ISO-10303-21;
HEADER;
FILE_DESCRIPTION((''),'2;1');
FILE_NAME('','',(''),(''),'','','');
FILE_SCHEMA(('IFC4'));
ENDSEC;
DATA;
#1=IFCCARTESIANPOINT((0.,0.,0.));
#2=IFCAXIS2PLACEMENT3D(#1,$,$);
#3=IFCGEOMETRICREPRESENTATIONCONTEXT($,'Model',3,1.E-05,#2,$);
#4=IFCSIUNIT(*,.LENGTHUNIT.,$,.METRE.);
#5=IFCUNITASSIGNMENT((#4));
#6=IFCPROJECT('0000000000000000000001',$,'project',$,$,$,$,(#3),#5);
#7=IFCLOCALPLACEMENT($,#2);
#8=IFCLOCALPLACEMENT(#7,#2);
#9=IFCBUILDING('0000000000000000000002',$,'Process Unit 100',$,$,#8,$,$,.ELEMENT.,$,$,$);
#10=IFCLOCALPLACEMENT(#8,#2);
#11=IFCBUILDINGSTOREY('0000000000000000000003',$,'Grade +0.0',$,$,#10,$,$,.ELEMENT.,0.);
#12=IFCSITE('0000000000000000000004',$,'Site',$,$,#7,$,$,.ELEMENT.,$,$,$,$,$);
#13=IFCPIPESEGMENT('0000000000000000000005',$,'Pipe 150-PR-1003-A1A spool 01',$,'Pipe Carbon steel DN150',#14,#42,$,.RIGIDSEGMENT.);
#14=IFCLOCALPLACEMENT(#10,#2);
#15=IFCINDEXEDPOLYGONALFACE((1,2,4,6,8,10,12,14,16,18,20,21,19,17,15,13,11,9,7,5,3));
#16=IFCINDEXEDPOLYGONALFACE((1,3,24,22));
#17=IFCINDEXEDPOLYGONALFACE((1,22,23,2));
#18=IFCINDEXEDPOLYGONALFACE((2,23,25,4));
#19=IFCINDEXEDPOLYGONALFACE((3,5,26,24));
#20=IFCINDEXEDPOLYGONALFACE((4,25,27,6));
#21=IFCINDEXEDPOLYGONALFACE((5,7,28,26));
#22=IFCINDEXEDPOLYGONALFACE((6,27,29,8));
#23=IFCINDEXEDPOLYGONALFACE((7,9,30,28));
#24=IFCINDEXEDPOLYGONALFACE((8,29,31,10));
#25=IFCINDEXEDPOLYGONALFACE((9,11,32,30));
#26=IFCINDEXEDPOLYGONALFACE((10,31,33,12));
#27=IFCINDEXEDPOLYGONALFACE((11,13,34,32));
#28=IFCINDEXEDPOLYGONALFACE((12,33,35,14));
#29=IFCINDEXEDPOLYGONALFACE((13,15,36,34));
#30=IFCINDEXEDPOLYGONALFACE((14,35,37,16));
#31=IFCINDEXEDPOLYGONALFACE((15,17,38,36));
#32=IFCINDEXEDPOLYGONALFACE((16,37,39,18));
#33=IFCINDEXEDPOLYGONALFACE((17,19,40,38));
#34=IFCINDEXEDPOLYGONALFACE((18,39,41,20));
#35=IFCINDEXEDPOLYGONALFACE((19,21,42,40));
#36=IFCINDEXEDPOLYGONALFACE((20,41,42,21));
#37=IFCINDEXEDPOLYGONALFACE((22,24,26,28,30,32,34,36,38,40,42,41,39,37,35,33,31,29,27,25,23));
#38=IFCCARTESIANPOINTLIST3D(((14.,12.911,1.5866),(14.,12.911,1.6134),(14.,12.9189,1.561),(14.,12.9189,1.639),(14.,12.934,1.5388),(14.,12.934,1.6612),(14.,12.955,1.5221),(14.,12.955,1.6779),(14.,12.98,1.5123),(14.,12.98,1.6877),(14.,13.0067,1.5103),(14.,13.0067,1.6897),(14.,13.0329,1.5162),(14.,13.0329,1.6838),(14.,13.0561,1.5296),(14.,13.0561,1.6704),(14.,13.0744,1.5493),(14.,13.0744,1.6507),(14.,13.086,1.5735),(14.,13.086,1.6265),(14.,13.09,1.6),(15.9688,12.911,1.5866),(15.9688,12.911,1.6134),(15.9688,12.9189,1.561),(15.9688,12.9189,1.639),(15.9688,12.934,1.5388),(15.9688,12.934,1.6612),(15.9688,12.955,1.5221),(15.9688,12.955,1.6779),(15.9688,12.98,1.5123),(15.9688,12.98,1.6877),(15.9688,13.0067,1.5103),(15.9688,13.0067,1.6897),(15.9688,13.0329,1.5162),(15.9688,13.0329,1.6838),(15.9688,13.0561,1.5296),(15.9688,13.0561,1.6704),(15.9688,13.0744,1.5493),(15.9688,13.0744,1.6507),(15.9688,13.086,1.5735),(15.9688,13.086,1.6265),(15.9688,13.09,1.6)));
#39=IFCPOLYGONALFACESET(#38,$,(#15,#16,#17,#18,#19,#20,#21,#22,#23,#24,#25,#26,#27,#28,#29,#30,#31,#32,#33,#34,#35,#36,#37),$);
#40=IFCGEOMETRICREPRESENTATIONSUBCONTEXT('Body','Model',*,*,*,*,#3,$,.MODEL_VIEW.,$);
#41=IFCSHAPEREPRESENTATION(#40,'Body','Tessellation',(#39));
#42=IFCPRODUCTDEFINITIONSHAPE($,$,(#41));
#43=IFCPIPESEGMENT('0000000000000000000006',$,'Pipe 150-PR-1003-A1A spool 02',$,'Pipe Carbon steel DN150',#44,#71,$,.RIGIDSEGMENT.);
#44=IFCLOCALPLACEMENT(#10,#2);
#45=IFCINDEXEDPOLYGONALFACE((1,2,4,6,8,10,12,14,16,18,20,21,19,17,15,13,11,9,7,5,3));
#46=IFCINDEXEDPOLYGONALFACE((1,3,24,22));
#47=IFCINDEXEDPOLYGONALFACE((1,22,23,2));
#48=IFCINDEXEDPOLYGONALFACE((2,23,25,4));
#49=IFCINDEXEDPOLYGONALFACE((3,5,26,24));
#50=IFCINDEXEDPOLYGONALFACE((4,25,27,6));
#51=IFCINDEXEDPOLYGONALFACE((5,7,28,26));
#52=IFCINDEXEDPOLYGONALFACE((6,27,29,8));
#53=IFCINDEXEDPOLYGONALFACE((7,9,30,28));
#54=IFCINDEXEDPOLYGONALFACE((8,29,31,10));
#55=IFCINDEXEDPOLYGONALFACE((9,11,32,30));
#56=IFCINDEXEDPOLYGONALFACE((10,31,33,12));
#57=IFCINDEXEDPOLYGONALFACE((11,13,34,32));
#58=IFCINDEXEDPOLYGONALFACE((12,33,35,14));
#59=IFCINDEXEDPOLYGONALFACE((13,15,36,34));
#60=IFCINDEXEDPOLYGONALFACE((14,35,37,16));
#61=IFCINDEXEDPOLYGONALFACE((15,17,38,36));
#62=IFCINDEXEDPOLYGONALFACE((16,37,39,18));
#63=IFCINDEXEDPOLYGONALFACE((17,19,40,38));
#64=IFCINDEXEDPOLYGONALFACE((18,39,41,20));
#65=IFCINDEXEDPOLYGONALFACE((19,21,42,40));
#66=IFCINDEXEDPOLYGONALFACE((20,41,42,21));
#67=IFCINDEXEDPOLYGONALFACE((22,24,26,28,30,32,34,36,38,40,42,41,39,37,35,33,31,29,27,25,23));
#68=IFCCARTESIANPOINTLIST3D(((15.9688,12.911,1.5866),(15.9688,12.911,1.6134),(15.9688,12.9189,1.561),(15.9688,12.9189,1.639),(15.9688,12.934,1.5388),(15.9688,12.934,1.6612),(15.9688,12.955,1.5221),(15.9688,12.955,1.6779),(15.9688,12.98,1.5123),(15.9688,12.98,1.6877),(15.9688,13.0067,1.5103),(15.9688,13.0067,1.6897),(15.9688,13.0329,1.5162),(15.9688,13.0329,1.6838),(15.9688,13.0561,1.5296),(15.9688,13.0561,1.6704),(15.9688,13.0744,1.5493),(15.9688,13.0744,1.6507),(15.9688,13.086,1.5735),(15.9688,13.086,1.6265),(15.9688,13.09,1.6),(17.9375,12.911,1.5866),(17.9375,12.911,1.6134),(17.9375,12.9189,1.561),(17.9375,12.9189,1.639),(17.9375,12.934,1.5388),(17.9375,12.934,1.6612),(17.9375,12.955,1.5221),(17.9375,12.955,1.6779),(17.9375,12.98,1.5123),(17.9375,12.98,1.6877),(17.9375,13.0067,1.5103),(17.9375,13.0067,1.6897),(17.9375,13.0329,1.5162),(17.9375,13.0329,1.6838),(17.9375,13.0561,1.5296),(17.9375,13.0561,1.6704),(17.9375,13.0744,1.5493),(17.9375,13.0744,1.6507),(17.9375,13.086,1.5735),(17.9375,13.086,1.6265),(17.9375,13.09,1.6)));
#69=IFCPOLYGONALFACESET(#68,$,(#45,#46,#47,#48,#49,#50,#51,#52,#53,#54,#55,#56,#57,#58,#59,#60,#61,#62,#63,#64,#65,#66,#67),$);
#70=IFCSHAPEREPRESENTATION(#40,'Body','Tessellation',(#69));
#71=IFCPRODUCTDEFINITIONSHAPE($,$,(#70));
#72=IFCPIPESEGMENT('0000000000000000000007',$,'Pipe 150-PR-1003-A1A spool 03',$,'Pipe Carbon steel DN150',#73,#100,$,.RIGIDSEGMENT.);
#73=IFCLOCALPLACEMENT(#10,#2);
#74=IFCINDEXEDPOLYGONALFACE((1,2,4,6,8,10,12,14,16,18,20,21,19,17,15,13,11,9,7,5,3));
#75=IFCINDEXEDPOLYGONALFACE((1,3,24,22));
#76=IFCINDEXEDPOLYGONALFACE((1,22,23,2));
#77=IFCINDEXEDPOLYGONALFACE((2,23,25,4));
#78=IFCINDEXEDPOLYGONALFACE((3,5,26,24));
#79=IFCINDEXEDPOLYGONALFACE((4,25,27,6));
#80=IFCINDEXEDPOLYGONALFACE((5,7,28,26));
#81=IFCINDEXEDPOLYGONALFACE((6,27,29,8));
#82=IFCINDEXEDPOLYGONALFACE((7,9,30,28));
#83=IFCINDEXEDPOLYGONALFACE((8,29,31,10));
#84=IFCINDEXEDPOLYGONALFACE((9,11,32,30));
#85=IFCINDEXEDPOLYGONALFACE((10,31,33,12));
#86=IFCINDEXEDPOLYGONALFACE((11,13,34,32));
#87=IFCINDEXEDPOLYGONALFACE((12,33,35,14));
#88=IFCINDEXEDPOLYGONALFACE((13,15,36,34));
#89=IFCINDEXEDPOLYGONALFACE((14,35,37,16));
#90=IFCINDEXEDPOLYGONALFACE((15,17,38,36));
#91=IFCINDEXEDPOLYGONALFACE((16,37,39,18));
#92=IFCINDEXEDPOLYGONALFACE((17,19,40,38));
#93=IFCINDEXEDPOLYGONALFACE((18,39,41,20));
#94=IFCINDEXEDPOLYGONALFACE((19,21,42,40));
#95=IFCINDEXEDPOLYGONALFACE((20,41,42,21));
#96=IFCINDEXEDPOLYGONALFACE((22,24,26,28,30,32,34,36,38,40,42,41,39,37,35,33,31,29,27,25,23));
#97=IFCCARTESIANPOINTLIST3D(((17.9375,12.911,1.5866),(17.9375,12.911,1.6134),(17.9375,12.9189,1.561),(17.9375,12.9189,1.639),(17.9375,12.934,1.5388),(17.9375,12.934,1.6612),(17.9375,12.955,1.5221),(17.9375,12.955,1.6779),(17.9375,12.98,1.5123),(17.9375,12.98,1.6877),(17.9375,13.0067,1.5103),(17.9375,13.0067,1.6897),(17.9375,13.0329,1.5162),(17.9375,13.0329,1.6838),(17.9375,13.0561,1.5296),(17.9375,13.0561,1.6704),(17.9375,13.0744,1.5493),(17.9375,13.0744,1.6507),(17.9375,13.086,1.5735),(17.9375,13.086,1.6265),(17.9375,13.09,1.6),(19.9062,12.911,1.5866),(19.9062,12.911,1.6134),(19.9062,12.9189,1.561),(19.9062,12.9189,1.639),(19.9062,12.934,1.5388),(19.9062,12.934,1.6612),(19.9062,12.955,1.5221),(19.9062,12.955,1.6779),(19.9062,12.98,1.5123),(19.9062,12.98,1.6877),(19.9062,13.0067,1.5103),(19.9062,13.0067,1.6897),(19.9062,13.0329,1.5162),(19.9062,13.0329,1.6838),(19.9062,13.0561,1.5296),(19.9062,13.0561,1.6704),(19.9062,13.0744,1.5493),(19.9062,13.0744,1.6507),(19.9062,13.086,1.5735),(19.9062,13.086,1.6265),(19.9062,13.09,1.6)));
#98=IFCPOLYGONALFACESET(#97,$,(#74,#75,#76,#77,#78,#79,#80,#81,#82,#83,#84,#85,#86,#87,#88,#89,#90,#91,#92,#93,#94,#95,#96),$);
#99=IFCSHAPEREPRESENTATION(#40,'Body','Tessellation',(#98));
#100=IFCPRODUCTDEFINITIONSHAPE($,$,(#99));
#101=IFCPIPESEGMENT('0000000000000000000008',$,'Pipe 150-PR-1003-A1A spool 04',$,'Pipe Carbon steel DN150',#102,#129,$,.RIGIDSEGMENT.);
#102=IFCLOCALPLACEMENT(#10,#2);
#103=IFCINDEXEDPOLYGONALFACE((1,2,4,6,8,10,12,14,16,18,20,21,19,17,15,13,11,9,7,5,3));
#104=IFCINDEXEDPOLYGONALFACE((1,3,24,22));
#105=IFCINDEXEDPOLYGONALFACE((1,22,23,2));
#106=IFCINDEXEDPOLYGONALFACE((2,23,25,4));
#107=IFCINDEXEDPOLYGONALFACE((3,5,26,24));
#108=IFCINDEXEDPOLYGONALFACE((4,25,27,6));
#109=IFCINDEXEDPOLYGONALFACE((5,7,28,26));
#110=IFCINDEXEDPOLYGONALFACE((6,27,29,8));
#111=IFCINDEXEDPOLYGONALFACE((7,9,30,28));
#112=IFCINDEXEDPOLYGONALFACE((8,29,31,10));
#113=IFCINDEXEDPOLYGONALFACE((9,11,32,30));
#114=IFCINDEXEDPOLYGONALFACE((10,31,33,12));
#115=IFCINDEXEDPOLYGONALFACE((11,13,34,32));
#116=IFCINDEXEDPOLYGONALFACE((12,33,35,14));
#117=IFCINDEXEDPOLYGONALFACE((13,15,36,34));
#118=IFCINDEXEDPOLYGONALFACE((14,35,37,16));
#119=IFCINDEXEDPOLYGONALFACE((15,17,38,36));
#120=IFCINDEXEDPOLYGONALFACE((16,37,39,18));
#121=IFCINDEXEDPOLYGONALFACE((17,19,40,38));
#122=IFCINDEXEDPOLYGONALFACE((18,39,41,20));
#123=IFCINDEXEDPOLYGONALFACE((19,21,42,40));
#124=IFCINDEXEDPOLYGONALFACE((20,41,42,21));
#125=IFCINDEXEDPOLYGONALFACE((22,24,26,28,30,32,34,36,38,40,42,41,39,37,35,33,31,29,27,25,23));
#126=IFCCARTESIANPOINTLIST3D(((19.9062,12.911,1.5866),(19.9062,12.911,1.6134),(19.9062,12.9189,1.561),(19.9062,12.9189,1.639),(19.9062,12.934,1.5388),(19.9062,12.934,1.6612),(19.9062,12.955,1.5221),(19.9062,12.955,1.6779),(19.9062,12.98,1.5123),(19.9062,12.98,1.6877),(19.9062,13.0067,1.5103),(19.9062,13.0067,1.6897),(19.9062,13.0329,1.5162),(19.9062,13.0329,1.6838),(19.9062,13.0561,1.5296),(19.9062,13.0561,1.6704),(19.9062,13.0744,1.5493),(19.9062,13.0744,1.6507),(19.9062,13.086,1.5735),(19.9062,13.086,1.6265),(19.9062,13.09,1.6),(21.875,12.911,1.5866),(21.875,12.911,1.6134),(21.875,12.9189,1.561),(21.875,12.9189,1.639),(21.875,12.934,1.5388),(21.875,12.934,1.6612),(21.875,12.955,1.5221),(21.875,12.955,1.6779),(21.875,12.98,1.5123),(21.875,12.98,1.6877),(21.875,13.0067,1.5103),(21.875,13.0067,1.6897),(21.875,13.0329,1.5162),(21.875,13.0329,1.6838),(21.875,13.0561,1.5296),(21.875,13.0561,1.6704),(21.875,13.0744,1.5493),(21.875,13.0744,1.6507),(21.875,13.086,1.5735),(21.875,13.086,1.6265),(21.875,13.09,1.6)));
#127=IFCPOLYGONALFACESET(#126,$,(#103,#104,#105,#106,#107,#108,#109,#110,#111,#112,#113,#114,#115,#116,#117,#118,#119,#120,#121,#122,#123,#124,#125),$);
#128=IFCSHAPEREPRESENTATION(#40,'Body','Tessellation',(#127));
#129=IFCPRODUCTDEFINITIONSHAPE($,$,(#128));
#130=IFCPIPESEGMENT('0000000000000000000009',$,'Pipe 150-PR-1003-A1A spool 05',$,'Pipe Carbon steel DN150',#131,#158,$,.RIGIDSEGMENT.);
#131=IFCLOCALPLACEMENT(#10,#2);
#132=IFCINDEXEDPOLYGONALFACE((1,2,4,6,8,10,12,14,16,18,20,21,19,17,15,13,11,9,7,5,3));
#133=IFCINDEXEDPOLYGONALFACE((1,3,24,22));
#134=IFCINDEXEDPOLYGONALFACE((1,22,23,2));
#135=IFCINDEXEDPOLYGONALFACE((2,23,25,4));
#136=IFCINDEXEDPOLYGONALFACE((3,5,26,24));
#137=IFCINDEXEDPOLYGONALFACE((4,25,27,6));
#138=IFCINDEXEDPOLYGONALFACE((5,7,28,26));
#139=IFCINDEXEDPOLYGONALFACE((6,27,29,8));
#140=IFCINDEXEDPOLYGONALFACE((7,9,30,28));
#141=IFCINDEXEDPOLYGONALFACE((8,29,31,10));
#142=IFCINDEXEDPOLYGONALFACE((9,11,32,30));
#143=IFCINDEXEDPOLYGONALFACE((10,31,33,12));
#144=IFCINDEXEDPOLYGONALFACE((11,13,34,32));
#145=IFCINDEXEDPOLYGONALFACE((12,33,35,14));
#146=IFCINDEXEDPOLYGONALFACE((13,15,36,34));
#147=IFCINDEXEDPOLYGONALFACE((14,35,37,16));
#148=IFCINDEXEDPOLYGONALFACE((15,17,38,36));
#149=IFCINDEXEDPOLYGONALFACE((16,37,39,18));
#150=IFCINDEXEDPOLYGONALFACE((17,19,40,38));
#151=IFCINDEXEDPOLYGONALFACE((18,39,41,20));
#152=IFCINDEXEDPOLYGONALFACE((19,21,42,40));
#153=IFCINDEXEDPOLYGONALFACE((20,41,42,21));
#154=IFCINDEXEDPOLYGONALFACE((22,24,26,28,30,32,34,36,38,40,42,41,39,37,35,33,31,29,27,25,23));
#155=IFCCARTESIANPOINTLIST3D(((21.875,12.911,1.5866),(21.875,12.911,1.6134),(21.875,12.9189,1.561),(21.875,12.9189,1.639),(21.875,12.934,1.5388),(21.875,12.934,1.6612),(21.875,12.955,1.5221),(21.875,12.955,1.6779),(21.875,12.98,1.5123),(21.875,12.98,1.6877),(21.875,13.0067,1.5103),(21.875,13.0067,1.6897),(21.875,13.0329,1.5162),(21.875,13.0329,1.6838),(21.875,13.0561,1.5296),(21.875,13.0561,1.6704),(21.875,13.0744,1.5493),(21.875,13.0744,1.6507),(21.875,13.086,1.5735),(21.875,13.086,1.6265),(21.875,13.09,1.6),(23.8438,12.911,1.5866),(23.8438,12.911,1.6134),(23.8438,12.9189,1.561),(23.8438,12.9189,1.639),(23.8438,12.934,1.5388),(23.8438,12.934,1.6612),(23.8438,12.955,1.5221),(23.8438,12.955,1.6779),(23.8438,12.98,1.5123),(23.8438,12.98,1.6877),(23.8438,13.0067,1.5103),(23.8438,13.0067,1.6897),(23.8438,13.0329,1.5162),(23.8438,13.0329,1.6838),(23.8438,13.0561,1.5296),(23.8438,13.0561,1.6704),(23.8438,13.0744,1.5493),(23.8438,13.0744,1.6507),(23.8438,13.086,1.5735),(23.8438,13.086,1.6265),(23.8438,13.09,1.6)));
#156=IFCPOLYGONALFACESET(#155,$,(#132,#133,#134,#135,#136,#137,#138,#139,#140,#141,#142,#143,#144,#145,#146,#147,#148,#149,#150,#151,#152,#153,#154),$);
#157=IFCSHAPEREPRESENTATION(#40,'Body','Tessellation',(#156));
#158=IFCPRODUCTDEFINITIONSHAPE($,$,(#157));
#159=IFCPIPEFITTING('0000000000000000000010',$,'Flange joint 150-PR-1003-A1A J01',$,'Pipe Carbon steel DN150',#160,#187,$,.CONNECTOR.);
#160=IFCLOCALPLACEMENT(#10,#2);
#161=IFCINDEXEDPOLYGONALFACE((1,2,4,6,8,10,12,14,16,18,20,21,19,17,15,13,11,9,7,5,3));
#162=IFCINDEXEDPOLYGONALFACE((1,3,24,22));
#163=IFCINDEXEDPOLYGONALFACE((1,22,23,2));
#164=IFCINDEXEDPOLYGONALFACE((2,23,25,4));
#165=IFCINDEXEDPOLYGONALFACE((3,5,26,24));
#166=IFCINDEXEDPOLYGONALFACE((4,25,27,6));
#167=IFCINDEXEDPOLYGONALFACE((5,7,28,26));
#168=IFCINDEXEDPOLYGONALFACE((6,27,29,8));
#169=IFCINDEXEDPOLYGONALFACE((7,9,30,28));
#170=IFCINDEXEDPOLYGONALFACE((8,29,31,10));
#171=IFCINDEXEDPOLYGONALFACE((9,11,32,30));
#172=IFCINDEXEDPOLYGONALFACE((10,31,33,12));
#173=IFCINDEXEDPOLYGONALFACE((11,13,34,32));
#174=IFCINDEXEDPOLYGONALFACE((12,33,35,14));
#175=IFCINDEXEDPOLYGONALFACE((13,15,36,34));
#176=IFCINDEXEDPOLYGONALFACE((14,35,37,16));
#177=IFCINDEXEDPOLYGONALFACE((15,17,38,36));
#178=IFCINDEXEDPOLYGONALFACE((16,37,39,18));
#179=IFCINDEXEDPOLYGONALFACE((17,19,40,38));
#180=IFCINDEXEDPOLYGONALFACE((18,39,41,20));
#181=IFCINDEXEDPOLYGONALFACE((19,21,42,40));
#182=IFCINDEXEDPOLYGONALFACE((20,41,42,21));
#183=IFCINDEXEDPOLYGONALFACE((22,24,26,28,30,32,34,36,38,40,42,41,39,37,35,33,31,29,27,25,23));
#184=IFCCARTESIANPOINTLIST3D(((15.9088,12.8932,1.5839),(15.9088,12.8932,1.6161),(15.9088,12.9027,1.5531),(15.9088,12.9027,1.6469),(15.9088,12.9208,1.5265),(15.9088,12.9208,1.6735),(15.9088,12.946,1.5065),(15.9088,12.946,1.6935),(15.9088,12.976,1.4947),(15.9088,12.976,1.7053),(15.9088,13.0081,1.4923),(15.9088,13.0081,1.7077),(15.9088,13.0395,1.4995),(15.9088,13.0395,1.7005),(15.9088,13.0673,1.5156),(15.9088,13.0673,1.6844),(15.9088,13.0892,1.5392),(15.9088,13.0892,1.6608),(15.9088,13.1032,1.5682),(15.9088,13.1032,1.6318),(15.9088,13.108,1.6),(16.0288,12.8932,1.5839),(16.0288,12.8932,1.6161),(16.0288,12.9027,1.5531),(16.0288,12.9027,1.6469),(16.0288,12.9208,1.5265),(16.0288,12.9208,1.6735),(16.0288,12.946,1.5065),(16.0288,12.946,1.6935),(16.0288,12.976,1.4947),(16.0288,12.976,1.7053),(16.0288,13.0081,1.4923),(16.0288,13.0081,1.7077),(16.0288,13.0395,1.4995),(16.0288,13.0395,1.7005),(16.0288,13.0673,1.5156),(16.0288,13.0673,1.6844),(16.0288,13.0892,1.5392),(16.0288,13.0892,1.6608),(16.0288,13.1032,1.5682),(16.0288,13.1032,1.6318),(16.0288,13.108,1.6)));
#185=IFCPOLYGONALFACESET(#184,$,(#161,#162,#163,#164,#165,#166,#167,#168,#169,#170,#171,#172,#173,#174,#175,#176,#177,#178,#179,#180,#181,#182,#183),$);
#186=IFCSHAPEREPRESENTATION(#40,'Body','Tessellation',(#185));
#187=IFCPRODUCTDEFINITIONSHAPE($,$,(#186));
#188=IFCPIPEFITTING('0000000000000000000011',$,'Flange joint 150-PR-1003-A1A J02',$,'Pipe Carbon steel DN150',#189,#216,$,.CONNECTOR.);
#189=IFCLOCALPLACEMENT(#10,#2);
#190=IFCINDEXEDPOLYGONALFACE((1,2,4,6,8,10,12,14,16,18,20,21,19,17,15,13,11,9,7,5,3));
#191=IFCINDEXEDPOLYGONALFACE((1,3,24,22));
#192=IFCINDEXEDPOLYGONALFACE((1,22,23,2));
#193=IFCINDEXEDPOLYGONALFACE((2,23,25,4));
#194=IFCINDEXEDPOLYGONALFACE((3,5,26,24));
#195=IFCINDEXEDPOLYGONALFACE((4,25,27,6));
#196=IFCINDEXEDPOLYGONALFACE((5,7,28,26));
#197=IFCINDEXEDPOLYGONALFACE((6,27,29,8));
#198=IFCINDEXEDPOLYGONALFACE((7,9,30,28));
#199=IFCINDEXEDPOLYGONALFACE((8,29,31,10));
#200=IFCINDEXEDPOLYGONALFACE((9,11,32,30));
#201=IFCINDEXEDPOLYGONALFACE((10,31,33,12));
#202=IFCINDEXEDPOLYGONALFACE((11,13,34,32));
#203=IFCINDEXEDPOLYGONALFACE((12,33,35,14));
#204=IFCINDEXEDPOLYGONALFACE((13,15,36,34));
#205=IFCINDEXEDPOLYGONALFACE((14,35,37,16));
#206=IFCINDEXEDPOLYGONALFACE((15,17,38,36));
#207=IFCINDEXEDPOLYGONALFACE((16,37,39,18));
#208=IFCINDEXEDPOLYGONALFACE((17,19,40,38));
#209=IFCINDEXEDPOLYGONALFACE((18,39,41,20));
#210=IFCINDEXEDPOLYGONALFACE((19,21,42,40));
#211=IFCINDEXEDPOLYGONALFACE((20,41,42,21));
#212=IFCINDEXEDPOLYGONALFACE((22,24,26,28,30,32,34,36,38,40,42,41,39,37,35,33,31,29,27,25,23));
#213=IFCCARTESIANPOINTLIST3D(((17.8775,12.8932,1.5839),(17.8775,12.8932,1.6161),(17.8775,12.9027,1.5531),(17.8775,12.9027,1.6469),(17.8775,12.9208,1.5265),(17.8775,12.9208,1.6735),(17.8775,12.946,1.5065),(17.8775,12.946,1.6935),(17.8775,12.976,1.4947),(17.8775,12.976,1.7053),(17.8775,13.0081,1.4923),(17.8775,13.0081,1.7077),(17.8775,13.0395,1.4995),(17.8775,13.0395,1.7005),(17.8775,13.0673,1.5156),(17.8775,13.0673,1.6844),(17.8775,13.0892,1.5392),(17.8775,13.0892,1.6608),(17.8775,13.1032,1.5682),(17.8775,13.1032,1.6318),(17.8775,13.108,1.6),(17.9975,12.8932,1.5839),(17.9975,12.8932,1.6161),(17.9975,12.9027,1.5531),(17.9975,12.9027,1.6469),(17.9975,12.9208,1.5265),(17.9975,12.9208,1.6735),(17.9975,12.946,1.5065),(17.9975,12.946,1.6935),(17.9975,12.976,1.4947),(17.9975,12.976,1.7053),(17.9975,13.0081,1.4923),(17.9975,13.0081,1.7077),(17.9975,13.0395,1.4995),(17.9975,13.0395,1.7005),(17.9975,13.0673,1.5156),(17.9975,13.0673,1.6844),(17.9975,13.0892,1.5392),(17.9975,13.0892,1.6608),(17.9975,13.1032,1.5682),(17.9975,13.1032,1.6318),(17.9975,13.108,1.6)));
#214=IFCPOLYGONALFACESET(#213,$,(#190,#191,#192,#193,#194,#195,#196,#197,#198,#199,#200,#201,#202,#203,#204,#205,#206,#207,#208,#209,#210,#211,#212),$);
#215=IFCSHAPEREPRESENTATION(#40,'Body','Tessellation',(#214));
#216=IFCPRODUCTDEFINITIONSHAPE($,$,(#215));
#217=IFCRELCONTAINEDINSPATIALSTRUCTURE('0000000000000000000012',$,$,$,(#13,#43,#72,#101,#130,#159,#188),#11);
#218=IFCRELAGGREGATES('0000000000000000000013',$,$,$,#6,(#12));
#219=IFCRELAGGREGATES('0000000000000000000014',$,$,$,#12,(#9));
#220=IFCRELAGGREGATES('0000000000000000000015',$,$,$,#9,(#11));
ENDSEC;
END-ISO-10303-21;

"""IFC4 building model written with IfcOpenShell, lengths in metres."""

from ifc_helpers import new_model, si_unit, frame, origin, place, context, subcontext, project, spatial, circle, extrude, element, save


model = new_model("IFC4")

# Units and contexts
model_context = context("Model", 3, precision=1e-05, world=origin())
body_context = subcontext(model_context, "Body", "Model", "MODEL_VIEW")
ifc_project = project(units=[si_unit("LENGTHUNIT", "METRE")], contexts=[model_context])

# Site, building, storey
site_placement = place(None, origin())
site = spatial("IfcSite", under=ifc_project, at=site_placement, Name="Site", CompositionType="ELEMENT")
building_placement = place(site_placement, origin())
building = spatial("IfcBuilding", under=site, at=building_placement, Name="Process Unit 100", CompositionType="ELEMENT")
storey_placement = place(building_placement, origin())
storey = spatial("IfcBuildingStorey", under=building, at=storey_placement, Name="Grade +0.0", CompositionType="ELEMENT", Elevation=0.0)

# Pipe segments
for number, where, z_axis, x_axis, name in (
    (1, (14.0, 13.0, 1.6), (1.0, 0.0, 0.0), (0.0, 1.0, 0.0), "Pipe 150-PR-1003-A1A spool 01"),
    (2, (15.9688, 13.0, 1.6), (1.0, 0.0, 0.0), (0.0, 1.0, 0.0), "Pipe 150-PR-1003-A1A spool 02"),
    (3, (17.9375, 13.0, 1.6), (1.0, 0.0, 0.0), (0.0, 1.0, 0.0), "Pipe 150-PR-1003-A1A spool 03"),
    (4, (19.9062, 13.0, 1.6), (1.0, 0.0, 0.0), (0.0, 1.0, 0.0), "Pipe 150-PR-1003-A1A spool 04"),
    (5, (21.875, 13.0, 1.6), (1.0, 0.0, 0.0), (0.0, 1.0, 0.0), "Pipe 150-PR-1003-A1A spool 05"),
):
    element("IfcPipeSegment", number, at=place(storey_placement, frame(where, z_axis=z_axis, x_axis=x_axis)), inside=storey, Name=name, ObjectType="Pipe Carbon steel DN150", PredefinedType="RIGIDSEGMENT", context=body_context, shape_type="SweptSolid", body=[
        extrude(circle(Radius=0.09), origin(), (0.0, 0.0, 1.0), 1.9688),
    ])

# Pipe fittings
for number, where, z_axis, x_axis, name in (
    (6, (15.9087, 13.0, 1.6), (1.0, 0.0, 0.0), (0.0, 1.0, 0.0), "Flange joint 150-PR-1003-A1A J01"),
    (7, (17.8775, 13.0, 1.6), (1.0, 0.0, 0.0), (0.0, 1.0, 0.0), "Flange joint 150-PR-1003-A1A J02"),
):
    element("IfcPipeFitting", number, at=place(storey_placement, frame(where, z_axis=z_axis, x_axis=x_axis)), inside=storey, Name=name, ObjectType="Pipe Carbon steel DN150", PredefinedType="CONNECTOR", context=body_context, shape_type="SweptSolid", body=[
        extrude(circle(Radius=0.108), origin(), (0.0, 0.0, 1.0), 0.12),
    ])

save(model, "model.ifc")
